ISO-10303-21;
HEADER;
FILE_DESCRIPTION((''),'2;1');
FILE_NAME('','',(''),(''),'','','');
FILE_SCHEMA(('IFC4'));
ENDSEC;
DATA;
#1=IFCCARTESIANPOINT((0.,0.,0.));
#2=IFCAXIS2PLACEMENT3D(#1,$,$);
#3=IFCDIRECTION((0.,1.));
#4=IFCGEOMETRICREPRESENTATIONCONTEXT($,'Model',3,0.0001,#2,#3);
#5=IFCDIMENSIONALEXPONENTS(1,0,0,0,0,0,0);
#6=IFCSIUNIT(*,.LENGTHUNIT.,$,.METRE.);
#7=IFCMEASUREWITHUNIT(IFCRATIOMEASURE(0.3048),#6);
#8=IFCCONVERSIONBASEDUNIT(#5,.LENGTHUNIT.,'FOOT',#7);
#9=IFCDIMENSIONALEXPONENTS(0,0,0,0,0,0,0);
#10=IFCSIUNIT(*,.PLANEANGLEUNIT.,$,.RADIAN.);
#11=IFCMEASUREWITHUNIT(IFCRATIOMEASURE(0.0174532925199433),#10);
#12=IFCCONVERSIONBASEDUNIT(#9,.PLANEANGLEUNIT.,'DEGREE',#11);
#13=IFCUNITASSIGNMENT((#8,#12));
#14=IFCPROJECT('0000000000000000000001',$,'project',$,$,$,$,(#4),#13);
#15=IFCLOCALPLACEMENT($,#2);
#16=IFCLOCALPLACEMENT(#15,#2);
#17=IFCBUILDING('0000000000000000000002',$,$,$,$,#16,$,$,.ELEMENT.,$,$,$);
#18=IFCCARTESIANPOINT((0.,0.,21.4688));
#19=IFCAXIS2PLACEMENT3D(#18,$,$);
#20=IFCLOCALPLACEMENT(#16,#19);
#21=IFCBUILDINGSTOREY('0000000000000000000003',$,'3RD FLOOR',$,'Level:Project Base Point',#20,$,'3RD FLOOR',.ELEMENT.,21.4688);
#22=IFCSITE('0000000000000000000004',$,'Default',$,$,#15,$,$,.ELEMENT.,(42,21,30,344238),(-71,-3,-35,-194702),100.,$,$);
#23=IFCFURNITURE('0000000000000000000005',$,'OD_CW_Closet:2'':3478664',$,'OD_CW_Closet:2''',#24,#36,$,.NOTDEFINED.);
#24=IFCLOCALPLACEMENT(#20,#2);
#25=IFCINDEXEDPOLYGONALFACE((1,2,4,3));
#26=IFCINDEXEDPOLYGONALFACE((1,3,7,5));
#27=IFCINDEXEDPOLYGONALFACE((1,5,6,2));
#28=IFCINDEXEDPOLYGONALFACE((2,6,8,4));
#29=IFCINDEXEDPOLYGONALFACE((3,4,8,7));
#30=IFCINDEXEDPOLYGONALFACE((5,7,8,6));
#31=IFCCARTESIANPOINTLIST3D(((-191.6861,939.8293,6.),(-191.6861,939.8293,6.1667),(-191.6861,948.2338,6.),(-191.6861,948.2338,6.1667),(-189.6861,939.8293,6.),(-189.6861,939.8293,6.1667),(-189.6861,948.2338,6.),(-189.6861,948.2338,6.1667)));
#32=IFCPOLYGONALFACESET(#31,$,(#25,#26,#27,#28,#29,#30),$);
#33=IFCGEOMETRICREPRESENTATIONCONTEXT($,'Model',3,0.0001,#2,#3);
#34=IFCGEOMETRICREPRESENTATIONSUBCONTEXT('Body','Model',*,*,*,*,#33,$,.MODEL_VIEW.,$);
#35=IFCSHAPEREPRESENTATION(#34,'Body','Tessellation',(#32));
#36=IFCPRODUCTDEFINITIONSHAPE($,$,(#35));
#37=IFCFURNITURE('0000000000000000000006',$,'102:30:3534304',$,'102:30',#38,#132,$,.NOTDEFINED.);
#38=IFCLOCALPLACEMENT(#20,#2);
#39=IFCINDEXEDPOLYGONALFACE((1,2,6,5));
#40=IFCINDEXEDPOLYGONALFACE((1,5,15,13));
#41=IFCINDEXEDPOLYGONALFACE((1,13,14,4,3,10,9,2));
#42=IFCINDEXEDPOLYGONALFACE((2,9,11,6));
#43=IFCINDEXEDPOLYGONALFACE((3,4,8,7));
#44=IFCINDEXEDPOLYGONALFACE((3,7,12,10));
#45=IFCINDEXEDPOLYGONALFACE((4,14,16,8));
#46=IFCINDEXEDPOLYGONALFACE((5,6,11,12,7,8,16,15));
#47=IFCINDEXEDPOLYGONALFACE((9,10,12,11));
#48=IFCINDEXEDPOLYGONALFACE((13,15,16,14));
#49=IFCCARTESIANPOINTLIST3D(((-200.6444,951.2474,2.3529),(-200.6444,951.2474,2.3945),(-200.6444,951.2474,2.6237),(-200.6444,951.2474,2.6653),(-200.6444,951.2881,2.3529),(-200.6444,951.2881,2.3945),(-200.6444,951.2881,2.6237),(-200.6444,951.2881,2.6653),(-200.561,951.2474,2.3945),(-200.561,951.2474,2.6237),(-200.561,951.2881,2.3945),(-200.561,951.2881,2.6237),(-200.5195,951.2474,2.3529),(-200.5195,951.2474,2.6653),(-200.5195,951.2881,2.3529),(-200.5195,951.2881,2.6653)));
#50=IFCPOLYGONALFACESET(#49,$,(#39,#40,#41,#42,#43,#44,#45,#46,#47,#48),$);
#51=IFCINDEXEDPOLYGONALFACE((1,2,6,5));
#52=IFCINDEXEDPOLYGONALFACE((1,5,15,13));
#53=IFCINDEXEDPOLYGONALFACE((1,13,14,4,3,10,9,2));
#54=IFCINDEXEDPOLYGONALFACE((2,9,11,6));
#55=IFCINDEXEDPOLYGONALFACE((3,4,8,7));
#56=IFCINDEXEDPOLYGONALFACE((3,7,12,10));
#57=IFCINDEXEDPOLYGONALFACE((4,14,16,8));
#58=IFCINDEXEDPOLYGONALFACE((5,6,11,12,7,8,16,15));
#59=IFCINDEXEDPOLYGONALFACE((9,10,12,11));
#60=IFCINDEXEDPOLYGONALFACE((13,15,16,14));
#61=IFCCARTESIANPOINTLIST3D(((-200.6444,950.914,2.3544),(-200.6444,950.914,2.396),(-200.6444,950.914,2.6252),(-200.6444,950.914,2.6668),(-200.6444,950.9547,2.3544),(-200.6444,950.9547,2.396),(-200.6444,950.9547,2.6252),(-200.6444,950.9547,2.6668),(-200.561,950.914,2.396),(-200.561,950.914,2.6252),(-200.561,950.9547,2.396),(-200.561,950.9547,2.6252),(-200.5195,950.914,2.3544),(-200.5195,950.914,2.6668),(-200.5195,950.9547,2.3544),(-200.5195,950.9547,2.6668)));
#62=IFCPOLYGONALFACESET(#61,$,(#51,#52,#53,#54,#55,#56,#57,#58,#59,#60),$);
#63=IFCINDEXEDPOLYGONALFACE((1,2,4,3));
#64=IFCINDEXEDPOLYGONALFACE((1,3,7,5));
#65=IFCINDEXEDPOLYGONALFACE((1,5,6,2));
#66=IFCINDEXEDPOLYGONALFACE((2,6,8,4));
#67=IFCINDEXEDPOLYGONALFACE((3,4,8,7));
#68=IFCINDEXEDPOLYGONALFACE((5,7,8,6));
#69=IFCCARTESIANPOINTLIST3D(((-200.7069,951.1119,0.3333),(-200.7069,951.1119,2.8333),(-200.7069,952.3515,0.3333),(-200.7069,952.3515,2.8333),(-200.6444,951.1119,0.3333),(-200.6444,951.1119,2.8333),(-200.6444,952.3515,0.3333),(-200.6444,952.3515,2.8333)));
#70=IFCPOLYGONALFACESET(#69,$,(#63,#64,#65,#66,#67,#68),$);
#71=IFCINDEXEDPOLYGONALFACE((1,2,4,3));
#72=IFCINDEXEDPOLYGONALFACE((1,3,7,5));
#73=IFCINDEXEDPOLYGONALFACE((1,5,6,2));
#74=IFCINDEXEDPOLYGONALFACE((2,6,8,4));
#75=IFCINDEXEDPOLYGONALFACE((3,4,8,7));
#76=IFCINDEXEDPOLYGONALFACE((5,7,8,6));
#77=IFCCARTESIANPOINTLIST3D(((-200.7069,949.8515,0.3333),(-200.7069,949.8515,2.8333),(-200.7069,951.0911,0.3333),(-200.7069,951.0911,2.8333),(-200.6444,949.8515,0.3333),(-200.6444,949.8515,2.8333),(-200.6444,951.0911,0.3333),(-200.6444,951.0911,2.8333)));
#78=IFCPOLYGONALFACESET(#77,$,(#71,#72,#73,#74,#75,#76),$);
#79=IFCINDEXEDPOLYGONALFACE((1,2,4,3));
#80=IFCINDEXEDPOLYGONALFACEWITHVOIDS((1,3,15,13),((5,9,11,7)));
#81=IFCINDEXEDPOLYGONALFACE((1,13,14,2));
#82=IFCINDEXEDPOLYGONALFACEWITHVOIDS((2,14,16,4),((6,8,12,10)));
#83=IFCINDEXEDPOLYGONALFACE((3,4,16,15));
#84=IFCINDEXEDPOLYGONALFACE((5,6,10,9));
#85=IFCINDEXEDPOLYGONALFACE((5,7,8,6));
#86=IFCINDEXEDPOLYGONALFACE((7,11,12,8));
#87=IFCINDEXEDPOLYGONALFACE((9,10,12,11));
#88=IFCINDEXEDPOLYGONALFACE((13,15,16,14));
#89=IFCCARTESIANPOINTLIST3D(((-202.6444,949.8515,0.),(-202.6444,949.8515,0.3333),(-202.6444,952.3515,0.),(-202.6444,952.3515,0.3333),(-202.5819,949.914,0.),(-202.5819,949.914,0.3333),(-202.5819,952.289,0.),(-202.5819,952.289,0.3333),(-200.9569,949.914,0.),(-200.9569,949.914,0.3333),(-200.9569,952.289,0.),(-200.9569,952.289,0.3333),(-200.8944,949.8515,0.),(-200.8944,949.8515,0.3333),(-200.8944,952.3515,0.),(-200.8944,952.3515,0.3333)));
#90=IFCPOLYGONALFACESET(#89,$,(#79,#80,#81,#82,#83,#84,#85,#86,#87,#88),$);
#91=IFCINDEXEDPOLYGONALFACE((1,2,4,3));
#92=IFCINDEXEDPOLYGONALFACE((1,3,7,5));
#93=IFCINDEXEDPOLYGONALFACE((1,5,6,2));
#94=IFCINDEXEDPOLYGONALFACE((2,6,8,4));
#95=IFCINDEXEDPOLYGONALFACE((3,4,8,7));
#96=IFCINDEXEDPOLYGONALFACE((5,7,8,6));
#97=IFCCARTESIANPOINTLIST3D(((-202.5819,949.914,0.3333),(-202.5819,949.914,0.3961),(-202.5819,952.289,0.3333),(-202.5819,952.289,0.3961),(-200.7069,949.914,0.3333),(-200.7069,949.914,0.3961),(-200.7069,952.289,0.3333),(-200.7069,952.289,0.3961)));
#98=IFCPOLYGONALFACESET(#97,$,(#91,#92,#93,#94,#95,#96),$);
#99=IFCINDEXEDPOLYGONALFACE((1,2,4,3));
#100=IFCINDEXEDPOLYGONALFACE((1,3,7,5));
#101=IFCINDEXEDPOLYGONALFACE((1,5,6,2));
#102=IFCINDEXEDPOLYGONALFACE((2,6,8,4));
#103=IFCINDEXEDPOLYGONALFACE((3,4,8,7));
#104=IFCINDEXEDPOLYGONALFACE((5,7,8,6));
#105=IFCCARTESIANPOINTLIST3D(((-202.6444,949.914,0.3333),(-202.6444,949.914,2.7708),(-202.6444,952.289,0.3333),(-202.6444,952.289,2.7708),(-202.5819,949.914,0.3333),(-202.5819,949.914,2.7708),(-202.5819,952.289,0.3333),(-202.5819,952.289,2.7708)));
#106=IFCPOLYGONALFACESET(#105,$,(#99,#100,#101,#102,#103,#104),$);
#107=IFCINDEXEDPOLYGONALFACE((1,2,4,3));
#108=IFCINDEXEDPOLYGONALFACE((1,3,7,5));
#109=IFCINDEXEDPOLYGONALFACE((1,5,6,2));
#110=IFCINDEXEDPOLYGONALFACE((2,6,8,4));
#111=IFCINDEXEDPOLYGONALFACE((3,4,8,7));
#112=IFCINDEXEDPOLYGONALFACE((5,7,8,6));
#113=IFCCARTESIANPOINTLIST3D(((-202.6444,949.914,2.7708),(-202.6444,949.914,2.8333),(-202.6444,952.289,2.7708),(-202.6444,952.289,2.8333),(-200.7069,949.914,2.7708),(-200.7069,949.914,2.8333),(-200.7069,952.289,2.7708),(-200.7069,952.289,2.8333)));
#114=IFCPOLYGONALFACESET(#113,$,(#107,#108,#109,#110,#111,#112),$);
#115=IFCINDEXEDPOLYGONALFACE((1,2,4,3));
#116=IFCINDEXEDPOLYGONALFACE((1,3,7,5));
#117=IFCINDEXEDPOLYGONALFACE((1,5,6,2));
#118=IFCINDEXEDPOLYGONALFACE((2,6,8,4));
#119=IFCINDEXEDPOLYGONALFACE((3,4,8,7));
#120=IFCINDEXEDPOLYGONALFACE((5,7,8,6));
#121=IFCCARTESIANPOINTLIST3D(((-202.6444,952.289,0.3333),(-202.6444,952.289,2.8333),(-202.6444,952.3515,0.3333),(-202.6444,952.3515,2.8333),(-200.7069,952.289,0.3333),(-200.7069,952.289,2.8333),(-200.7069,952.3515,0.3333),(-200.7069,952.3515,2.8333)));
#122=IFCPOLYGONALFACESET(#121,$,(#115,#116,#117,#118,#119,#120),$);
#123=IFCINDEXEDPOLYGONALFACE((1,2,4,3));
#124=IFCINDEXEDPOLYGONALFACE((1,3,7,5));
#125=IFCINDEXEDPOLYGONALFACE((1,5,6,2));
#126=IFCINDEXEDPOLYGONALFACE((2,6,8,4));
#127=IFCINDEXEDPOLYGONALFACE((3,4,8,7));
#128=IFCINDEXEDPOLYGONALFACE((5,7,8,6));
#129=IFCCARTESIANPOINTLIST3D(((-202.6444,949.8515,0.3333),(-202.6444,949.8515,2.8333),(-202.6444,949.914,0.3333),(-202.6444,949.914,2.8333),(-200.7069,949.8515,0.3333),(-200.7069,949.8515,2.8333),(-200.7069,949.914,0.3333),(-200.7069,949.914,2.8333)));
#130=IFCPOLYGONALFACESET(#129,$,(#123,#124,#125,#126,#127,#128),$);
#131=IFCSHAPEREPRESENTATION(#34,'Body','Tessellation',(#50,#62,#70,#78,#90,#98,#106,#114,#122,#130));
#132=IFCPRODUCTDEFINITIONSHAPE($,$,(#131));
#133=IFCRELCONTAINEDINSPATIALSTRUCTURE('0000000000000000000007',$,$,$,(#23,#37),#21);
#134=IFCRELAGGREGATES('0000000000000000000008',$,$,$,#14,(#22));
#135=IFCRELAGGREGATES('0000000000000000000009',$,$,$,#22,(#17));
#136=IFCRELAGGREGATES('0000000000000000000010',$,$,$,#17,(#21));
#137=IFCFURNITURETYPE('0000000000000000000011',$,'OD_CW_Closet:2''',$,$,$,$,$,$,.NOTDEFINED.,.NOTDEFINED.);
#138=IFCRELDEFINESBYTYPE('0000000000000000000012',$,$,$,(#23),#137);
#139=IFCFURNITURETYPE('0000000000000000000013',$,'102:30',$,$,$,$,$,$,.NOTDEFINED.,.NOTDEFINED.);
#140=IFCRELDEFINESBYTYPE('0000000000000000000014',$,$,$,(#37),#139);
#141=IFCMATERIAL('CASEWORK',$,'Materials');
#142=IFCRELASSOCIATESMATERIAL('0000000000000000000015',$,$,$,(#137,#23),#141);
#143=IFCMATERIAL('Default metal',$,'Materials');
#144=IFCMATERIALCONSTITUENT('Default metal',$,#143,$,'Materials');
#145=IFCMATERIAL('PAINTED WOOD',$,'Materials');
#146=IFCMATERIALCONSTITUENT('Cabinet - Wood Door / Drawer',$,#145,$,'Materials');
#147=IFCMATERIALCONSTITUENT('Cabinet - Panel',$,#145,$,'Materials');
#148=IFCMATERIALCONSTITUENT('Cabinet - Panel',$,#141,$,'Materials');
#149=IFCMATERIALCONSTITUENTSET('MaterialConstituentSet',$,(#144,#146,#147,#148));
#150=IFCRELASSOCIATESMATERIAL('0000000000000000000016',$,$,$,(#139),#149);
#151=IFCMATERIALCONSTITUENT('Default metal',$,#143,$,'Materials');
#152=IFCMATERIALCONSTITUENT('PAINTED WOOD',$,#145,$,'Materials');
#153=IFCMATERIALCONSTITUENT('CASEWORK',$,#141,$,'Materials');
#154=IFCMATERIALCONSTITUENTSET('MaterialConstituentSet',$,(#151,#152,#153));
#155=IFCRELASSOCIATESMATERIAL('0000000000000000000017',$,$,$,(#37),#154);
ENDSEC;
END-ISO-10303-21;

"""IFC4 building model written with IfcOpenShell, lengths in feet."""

from ifc_helpers import new_model, entity, si_unit, converted_unit, direction, frame, frame_2d, origin, origin_2d_with_axis, place, context, subcontext, project, spatial, polyline, rectangle, outline, extrude, source, transform, mapped, material, constituent, constituent_set, type_object, type_shapes, element, save


model = new_model("IFC4")

# Units and contexts
model_context_1 = context("Model", 3, precision=0.0001, world=origin(), true_north=direction((0.0, 1.0)))
model_context_2 = context("Model", 3, precision=0.0001, world=origin(), true_north=direction((0.0, 1.0)))
body_context = subcontext(model_context_2, "Body", "Model", "MODEL_VIEW")
ifc_project = project(units=[converted_unit("LENGTHUNIT", "FOOT", entity("IfcRatioMeasure", 0.3048), si_unit("LENGTHUNIT", "METRE"), dimensions=[1, 0, 0, 0, 0, 0, 0]), converted_unit("PLANEANGLEUNIT", "DEGREE", entity("IfcRatioMeasure", 0.0174532925199433), si_unit("PLANEANGLEUNIT", "RADIAN"), dimensions=[0, 0, 0, 0, 0, 0, 0])], contexts=[model_context_1])

# Site, building, storey
site_placement = place(None, origin())
site = spatial("IfcSite", under=ifc_project, at=site_placement, Name="Default", CompositionType="ELEMENT", RefLatitude=(42, 21, 30, 344238), RefLongitude=(-71, -3, -35, -194702), RefElevation=100.0)
building_placement = place(site_placement, origin())
building = spatial("IfcBuilding", under=site, at=building_placement, CompositionType="ELEMENT")
storey_placement = place(building_placement, frame((0.0, 0.0, 21.4688)))
storey = spatial("IfcBuildingStorey", under=building, at=storey_placement, Name="3RD FLOOR", ObjectType="Level:Project Base Point", LongName="3RD FLOOR", CompositionType="ELEMENT", Elevation=21.4688)

# Furniture
ifc_material_1 = material(Name="CASEWORK", Category="Materials")
furniture_type_1 = type_object("IfcFurnitureType", Name="OD_CW_Closet:2'", AssemblyPlace="NOTDEFINED", PredefinedType="NOTDEFINED", material=ifc_material_1)
shared_shape_1 = source(origin(), body_context, "Body", "SweptSolid", [
    extrude(rectangle(XDim=8.4045, YDim=2.0, at=frame_2d((0.0, 0.0), x_axis=(1.0, 0.0))), frame((4.2022, 1.0, 0.0)), (0.0, 0.0, 1.0), 0.1667),
])
type_shapes(furniture_type_1, [shared_shape_1])
furniture_1_placement = place(storey_placement, frame((-191.6861, 948.2338, 6.0), z_axis=(0.0, 0.0, 1.0), x_axis=(0.0, -1.0, 0.0)))
element("IfcFurniture", 1, at=furniture_1_placement, inside=storey, type_object=furniture_type_1, material=ifc_material_1, Name="OD_CW_Closet:2':3478664", ObjectType="OD_CW_Closet:2'", PredefinedType="NOTDEFINED", context=body_context, shape_type="MappedRepresentation", body=[
    mapped(shared_shape_1, transform((0.0, 0.0, 0.0), scale=1.0)),
])
ifc_material_2 = material(Name="Default metal", Category="Materials")
ifc_constituent_1 = constituent(ifc_material_2, Name="Default metal", Category="Materials")
ifc_material_3 = material(Name="PAINTED WOOD", Category="Materials")
ifc_constituent_2 = constituent(ifc_material_3, Name="PAINTED WOOD", Category="Materials")
ifc_constituent_3 = constituent(ifc_material_1, Name="CASEWORK", Category="Materials")
ifc_constituent_set_1 = constituent_set(constituents=[ifc_constituent_1, ifc_constituent_2, ifc_constituent_3], Name="MaterialConstituentSet")
ifc_constituent_4 = constituent(ifc_material_2, Name="Default metal", Category="Materials")
ifc_constituent_5 = constituent(ifc_material_3, Name="Cabinet - Wood Door / Drawer", Category="Materials")
ifc_constituent_6 = constituent(ifc_material_3, Name="Cabinet - Panel", Category="Materials")
ifc_constituent_7 = constituent(ifc_material_1, Name="Cabinet - Panel", Category="Materials")
ifc_constituent_set_2 = constituent_set(constituents=[ifc_constituent_4, ifc_constituent_5, ifc_constituent_6, ifc_constituent_7], Name="MaterialConstituentSet")
furniture_type_2 = type_object("IfcFurnitureType", Name="102:30", AssemblyPlace="NOTDEFINED", PredefinedType="NOTDEFINED", material=ifc_constituent_set_2)
shared_shape_2 = source(origin(), body_context, "Body", "SweptSolid", [
    extrude(outline(polyline([(0.1146, -0.0521), (0.1562, -0.0521), (0.1562, 0.0729), (-0.1562, 0.0729), (-0.1562, -0.0521), (-0.1146, -0.0521), (-0.1146, 0.0313), (0.1146, 0.0313), (0.1146, -0.0521)])), frame((0.2073, -2.0521, 2.5091), z_axis=(1.0, 0.0, 0.0), x_axis=(0.0, 0.0, 1.0)), (0.0, 0.0, 1.0), 0.0407),
    extrude(outline(polyline([(0.1146, -0.0521), (0.1562, -0.0521), (0.1562, 0.0729), (-0.1562, 0.0729), (-0.1562, -0.0521), (-0.1146, -0.0521), (-0.1146, 0.0313), (0.1146, 0.0313), (0.1146, -0.0521)])), frame((-0.126, -2.0521, 2.5106), z_axis=(1.0, 0.0, 0.0), x_axis=(0.0, 0.0, 1.0)), (0.0, 0.0, 1.0), 0.0407),
    extrude(rectangle(XDim=0.0625, YDim=1.2396, at=frame_2d((0.0, 0.0), x_axis=(1.0, 0.0))), frame((0.6917, -1.9688, 0.3333), z_axis=(0.0, 0.0, 1.0), x_axis=(0.0, 1.0, 0.0)), (0.0, 0.0, 1.0), 2.5),
    extrude(rectangle(XDim=0.0625, YDim=1.2396, at=origin_2d_with_axis()), frame((-0.5687, -1.9688, 0.3333), z_axis=(0.0, 0.0, 1.0), x_axis=(0.0, 1.0, 0.0)), (0.0, 0.0, 1.0), 2.5),
    extrude(outline(polyline([(-1.25, -0.875), (1.25, -0.875), (1.25, 0.875), (-1.25, 0.875), (-1.25, -0.875)]), holes=[polyline([(-1.1875, -0.8125), (-1.1875, 0.8125), (1.1875, 0.8125), (1.1875, -0.8125), (-1.1875, -0.8125)])]), frame((0.0615, -0.875, 0.0)), (0.0, 0.0, 1.0), 0.3333),
    extrude(rectangle(XDim=2.375, YDim=1.875, at=frame_2d((0.0, 0.0), x_axis=(1.0, 0.0))), frame((0.0615, -1.0, 0.3333), z_axis=(0.0, 0.0, 1.0), x_axis=(-1.0, 0.0, 0.0)), (0.0, 0.0, 1.0), 0.0627),
    extrude(rectangle(XDim=0.0625, YDim=2.375, at=origin_2d_with_axis()), frame((0.0615, -0.0312, 0.3333), z_axis=(0.0, 0.0, 1.0), x_axis=(0.0, 1.0, 0.0)), (0.0, 0.0, 1.0), 2.4375),
    extrude(rectangle(XDim=2.375, YDim=1.9375, at=origin_2d_with_axis()), frame((0.0615, -0.9688, 2.7708), z_axis=(0.0, 0.0, 1.0), x_axis=(-1.0, 0.0, 0.0)), (0.0, 0.0, 1.0), 0.0625),
    extrude(rectangle(XDim=0.0625, YDim=1.9375, at=frame_2d((0.0, 0.0), x_axis=(1.0, 0.0))), frame((1.2802, -0.9687, 0.3333)), (0.0, 0.0, 1.0), 2.5),
    extrude(rectangle(XDim=0.0625, YDim=1.9375, at=frame_2d((0.0, 0.0), x_axis=(1.0, 0.0))), frame((-1.1573, -0.9687, 0.3333)), (0.0, 0.0, 1.0), 2.5),
])
type_shapes(furniture_type_2, [shared_shape_2])
furniture_2_placement = place(storey_placement, frame((-202.6444, 951.04, 0.0), z_axis=(0.0, 0.0, 1.0), x_axis=(0.0, 1.0, 0.0)))
element("IfcFurniture", 2, at=furniture_2_placement, inside=storey, type_object=furniture_type_2, material=ifc_constituent_set_1, Name="102:30:3534304", ObjectType="102:30", PredefinedType="NOTDEFINED", context=body_context, shape_type="MappedRepresentation", body=[
    mapped(shared_shape_2, transform((0.0, 0.0, 0.0), scale=1.0)),
])

save(model, "model.ifc")
